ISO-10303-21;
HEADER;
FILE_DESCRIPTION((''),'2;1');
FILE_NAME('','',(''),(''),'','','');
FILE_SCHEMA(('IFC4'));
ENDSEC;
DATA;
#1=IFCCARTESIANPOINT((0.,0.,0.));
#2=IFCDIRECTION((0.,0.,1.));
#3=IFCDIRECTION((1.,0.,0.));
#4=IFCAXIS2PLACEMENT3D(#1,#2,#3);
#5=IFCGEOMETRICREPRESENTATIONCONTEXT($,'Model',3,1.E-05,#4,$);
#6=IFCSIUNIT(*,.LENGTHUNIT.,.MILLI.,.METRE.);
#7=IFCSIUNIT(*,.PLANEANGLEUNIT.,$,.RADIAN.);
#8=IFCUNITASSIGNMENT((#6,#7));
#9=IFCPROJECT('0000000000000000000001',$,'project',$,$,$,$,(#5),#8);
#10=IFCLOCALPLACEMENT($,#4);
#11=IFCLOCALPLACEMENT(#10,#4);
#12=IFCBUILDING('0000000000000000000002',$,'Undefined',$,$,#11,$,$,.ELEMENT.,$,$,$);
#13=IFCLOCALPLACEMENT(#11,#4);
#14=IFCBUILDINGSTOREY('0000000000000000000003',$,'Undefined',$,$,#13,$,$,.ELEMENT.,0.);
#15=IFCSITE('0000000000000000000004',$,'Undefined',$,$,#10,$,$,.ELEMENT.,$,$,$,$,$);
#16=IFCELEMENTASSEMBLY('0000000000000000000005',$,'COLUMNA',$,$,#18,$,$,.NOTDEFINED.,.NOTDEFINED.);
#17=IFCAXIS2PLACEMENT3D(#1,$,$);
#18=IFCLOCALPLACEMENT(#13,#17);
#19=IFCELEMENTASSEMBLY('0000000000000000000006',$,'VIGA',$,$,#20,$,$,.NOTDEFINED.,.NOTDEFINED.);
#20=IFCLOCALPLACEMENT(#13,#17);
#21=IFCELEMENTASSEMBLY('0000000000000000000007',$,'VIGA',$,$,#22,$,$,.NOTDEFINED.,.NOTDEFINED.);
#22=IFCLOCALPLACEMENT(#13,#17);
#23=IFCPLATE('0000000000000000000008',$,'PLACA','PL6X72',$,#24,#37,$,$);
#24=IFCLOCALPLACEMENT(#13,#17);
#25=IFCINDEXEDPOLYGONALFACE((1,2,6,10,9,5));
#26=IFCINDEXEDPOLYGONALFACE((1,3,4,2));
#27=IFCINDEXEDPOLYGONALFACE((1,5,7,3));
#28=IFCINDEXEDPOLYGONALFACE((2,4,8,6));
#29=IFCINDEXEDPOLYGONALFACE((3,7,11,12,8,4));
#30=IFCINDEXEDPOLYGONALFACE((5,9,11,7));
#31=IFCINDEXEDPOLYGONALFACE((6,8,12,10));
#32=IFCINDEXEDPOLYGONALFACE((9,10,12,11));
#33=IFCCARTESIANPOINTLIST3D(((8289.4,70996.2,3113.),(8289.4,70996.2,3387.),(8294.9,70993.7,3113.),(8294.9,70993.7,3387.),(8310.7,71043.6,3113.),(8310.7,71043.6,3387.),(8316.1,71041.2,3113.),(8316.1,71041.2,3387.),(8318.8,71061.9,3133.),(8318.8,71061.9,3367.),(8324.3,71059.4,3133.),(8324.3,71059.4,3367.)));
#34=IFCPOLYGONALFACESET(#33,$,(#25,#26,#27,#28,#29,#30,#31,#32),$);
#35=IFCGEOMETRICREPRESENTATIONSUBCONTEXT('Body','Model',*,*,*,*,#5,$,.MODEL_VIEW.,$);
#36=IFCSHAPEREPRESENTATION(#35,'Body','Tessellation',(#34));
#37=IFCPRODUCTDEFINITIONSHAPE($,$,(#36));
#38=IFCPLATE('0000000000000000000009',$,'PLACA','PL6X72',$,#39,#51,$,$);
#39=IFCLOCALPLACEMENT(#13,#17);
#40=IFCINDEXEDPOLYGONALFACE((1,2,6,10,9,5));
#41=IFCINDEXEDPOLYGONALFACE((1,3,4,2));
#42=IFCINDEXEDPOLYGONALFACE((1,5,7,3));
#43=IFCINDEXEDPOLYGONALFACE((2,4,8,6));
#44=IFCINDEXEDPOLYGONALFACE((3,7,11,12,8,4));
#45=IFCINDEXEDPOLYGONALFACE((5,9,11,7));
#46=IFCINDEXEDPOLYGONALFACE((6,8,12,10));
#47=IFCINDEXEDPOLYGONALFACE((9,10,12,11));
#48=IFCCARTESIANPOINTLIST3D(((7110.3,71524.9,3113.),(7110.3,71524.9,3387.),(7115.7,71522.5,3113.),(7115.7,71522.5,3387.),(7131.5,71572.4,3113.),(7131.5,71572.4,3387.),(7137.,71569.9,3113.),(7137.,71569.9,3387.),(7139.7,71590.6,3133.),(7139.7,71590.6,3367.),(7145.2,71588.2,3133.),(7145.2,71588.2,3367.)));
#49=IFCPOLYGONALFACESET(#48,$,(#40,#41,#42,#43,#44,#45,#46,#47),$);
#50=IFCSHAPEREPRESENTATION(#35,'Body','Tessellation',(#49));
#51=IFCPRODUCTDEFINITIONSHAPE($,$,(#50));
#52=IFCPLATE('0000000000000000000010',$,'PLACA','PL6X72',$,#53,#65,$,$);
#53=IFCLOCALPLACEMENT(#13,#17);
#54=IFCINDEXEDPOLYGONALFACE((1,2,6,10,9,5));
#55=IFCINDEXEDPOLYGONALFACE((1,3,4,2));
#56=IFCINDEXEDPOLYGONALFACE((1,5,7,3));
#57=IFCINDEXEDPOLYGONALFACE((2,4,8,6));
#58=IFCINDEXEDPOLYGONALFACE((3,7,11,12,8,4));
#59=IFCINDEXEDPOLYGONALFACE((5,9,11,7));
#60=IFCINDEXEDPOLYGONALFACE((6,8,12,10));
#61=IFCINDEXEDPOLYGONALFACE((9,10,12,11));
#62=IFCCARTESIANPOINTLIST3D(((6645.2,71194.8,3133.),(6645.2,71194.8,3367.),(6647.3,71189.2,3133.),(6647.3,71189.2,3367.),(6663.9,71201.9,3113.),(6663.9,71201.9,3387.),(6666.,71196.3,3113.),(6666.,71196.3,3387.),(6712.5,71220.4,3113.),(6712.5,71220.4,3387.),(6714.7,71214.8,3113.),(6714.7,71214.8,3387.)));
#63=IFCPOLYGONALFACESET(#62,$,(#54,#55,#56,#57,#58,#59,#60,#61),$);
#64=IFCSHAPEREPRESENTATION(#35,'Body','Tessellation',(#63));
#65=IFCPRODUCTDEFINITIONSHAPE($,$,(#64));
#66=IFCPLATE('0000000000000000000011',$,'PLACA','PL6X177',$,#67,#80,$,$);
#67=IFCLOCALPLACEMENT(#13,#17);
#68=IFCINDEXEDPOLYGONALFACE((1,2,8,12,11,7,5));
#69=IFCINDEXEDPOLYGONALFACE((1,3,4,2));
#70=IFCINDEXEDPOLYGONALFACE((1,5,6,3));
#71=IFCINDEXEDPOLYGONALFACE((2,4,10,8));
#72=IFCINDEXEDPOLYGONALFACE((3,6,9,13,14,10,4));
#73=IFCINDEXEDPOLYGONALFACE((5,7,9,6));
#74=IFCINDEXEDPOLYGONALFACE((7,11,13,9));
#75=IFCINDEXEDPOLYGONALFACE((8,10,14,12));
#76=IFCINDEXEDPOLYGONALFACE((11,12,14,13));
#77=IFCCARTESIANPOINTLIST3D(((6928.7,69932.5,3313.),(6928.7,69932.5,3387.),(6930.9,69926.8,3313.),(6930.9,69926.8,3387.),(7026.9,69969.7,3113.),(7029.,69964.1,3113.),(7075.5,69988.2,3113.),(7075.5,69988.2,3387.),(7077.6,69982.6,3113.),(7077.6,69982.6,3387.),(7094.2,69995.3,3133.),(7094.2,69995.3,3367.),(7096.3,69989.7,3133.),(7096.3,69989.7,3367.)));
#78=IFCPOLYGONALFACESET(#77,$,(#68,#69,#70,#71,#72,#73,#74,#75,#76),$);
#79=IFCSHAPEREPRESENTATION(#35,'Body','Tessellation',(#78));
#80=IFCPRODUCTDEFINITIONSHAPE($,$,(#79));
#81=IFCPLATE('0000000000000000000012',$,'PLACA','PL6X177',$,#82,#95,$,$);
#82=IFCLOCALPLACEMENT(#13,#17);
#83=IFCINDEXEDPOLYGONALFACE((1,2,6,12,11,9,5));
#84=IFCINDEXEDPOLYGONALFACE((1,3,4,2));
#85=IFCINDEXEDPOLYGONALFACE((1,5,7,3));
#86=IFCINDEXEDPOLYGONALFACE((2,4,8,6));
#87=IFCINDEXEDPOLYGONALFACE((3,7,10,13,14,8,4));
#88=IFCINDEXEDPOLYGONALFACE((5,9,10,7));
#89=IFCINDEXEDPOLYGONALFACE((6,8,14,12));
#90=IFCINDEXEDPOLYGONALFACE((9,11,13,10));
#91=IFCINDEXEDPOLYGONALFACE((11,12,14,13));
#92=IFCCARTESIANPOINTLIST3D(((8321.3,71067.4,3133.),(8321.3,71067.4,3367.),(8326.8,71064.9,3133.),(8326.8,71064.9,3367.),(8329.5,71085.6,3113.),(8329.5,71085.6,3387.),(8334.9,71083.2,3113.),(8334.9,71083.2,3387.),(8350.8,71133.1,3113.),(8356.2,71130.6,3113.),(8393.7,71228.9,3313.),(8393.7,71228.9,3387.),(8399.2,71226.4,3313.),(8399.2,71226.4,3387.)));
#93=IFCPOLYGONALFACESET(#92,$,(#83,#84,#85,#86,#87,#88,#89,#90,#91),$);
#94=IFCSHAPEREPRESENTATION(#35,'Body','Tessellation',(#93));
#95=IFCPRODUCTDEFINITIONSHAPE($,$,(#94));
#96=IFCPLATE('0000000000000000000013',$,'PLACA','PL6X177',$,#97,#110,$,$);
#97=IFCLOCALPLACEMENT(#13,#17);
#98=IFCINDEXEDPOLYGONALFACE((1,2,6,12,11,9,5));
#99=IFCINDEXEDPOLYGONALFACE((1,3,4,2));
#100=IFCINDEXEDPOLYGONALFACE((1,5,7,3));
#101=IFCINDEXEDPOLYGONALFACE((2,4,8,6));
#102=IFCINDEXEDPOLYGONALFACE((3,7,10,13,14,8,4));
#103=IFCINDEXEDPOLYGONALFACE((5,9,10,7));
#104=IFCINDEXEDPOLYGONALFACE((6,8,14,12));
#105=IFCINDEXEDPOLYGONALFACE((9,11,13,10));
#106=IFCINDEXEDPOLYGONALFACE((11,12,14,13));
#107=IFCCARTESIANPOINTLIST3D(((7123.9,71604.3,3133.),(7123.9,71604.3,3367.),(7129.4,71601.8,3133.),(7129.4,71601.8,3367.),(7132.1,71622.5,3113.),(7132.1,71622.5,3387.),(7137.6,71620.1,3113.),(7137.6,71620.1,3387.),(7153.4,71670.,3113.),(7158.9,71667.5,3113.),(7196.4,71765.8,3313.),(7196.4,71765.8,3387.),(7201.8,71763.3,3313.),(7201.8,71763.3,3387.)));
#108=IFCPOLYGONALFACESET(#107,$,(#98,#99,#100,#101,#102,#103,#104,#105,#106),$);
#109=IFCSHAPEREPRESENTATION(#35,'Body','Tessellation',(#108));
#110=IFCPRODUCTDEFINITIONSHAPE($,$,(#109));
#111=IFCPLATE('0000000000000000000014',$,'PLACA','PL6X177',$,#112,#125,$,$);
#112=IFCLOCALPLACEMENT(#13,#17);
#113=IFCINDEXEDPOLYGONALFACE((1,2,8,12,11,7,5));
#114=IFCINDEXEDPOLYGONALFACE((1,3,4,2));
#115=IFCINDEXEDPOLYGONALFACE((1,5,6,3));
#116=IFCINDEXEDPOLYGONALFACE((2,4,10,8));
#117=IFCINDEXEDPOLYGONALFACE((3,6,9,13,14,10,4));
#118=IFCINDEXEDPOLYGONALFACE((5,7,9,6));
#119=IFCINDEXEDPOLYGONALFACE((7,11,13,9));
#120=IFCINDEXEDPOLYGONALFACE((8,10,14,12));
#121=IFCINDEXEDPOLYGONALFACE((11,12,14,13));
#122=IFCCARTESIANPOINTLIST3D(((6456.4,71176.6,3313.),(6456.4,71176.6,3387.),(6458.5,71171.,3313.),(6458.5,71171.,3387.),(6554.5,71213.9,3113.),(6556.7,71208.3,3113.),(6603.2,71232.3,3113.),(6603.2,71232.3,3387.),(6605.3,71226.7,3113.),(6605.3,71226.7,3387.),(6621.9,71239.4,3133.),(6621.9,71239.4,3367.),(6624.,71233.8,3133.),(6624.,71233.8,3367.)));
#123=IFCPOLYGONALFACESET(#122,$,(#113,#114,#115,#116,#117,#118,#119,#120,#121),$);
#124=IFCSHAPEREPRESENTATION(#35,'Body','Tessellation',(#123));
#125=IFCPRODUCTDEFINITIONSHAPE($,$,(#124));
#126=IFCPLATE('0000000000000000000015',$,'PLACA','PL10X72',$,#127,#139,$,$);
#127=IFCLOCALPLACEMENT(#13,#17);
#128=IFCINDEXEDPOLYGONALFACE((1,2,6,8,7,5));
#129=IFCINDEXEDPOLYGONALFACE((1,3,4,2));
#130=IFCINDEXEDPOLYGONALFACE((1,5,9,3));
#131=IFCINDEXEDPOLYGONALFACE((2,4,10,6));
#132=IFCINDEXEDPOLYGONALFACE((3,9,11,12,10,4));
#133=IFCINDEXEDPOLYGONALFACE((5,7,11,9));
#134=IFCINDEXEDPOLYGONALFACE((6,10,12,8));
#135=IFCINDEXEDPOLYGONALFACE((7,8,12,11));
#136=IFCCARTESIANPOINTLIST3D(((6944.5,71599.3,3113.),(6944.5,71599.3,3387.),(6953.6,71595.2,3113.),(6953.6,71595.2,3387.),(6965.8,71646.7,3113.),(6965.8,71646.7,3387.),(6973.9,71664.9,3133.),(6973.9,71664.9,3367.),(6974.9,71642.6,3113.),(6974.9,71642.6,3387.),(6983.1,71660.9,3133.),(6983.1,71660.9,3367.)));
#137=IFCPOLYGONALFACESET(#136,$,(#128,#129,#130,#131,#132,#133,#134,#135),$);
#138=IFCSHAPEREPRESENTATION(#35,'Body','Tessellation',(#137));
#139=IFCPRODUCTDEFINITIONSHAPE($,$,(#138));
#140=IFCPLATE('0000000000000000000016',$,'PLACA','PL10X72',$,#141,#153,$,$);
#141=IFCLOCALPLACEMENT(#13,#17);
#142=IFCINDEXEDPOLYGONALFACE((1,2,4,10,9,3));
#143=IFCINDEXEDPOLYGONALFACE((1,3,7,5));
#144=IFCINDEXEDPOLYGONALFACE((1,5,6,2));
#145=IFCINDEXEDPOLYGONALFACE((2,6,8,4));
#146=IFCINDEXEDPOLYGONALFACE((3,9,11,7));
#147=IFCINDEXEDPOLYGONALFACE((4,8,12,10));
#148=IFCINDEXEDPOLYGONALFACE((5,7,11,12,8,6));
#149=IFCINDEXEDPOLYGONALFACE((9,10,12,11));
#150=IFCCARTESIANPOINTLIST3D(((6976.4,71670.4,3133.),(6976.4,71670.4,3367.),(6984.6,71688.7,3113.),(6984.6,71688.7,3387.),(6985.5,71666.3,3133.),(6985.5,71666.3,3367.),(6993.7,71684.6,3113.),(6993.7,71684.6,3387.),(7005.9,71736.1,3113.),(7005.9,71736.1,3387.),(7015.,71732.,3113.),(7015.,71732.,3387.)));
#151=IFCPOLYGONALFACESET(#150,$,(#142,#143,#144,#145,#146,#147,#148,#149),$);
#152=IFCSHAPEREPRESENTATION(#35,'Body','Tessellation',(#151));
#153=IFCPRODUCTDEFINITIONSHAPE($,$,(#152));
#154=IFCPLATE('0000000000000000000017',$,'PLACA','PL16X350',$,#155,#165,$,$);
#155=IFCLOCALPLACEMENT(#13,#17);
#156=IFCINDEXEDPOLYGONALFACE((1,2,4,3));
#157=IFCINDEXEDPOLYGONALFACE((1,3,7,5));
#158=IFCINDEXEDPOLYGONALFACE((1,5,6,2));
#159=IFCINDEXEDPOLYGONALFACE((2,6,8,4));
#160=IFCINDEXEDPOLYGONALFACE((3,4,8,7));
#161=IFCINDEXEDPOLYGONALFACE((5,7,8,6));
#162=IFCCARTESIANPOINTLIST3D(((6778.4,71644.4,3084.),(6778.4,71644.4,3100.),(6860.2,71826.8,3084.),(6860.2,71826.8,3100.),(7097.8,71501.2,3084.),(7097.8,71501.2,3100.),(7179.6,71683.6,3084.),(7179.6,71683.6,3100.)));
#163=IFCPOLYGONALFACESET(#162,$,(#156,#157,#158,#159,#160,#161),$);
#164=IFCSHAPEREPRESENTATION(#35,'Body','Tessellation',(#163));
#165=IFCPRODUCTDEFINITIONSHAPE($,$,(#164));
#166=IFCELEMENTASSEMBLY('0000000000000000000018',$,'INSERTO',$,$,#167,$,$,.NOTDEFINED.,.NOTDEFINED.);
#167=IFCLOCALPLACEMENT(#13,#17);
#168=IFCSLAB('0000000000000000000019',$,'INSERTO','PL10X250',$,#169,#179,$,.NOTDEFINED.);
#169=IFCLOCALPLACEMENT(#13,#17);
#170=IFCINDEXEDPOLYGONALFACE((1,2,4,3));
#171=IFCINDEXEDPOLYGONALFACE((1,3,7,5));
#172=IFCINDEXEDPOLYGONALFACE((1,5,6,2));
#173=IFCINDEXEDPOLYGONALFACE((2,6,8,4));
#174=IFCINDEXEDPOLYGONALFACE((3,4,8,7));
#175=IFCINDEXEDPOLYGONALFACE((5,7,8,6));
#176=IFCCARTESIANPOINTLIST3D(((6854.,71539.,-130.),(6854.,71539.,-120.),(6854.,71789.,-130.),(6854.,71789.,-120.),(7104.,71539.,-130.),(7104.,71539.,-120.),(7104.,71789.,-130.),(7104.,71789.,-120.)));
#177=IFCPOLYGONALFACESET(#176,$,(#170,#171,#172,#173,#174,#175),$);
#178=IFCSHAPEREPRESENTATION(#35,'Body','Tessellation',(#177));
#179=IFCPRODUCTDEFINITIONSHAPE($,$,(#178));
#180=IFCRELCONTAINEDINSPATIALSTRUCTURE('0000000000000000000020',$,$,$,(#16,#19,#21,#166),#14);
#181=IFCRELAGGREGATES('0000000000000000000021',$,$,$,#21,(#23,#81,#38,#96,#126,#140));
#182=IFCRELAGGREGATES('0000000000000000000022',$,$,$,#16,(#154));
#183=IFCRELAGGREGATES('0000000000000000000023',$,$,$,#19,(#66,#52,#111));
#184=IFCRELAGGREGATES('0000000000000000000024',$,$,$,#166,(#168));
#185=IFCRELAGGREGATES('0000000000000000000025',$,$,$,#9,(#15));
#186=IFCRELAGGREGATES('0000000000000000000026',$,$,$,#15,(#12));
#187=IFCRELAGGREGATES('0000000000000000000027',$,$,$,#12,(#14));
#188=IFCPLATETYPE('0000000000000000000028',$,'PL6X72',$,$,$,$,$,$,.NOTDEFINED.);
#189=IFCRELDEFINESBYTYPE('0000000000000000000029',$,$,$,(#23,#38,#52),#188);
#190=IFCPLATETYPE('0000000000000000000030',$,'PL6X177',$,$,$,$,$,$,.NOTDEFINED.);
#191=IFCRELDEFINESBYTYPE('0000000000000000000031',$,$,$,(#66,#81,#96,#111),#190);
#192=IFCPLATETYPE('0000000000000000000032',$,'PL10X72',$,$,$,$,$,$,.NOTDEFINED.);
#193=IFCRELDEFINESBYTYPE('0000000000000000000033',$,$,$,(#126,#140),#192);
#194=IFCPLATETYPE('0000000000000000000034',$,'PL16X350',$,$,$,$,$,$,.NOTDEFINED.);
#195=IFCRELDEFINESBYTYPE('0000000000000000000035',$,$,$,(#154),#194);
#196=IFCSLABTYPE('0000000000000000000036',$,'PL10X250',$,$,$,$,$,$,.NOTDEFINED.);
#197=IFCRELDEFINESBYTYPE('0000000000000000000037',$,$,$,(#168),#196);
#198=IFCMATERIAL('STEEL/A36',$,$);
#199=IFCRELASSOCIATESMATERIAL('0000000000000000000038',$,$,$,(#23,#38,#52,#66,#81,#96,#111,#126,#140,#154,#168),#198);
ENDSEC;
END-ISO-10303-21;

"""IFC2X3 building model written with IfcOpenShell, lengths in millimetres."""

from ifc_helpers import new_model, si_unit, frame, origin_with_axes, place, context, subcontext, project, spatial, polyline, outline, extrude, material, type_object, element, aggregate, save


model = new_model("IFC2X3")

# Units and contexts
model_context = context("Model", 3, precision=1e-05, world=origin_with_axes())
body_context = subcontext(model_context, "Body", "Model", "MODEL_VIEW")
ifc_project = project(units=[si_unit("LENGTHUNIT", "METRE", prefix="MILLI"), si_unit("PLANEANGLEUNIT", "RADIAN")], contexts=[model_context])

# Site, building, storey
site_placement = place(None, origin_with_axes())
site = spatial("IfcSite", under=ifc_project, at=site_placement, Name="Undefined", CompositionType="ELEMENT")
building_placement = place(site_placement, origin_with_axes())
building = spatial("IfcBuilding", under=site, at=building_placement, Name="Undefined", CompositionType="ELEMENT")
storey_placement = place(building_placement, origin_with_axes())
storey = spatial("IfcBuildingStorey", under=building, at=storey_placement, Name="Undefined", CompositionType="ELEMENT", Elevation=0.0)

# Element assembly
assembly_1_placement = place(storey_placement, origin_with_axes())
assembly_1 = element("IfcElementAssembly", 1, at=assembly_1_placement, inside=storey, Name="COLUMNA", AssemblyPlace="NOTDEFINED", PredefinedType="NOTDEFINED")

# Shared definitions
ifc_material_1 = material(Name="STEEL/A36")

# Element assembly
assembly_2_placement = place(storey_placement, origin_with_axes())
assembly_2 = element("IfcElementAssembly", 2, at=assembly_2_placement, inside=storey, Name="VIGA", AssemblyPlace="NOTDEFINED", PredefinedType="NOTDEFINED")
plate_type_1 = type_object("IfcPlateType", Name="PL6X72", PredefinedType="NOTDEFINED")

# Element assembly, plates
assembly_3_placement = place(storey_placement, origin_with_axes())
assembly_3 = element("IfcElementAssembly", 3, at=assembly_3_placement, inside=storey, Name="VIGA", AssemblyPlace="NOTDEFINED", PredefinedType="NOTDEFINED")
plate_1_placement = place(assembly_3_placement, frame((8292.1, 70995.0, 3113.0), z_axis=(0.912465, -0.409155, 0.0), x_axis=(0.409155, 0.912465, 0.0)))
plate_1 = element("IfcPlate", 4, at=plate_1_placement, type_object=plate_type_1, material=ifc_material_1, Name="PLACA", Description="PL6X72", context=body_context, shape_type="SweptSolid", body=[
    extrude(outline(polyline([(0.0, 0.0), (52.0, 0.0), (72.0, 20.0), (72.0, 254.0), (52.0, 274.0), (0.0, 274.0), (0.0, 0.0)])), frame((0.0, 0.0, -3.0), z_axis=(0.0, 0.0, 1.0), x_axis=(1.0, 0.0, 0.0)), (0.0, 0.0, 1.0), 6.0),
])
plate_2_placement = place(assembly_3_placement, frame((7113.0, 71523.7, 3113.0), z_axis=(0.912465, -0.409155, 0.0), x_axis=(0.409155, 0.912465, 0.0)))
plate_2 = element("IfcPlate", 5, at=plate_2_placement, type_object=plate_type_1, material=ifc_material_1, Name="PLACA", Description="PL6X72", context=body_context, shape_type="SweptSolid", body=[
    extrude(outline(polyline([(0.0, 0.0), (52.0, 0.0), (72.0, 20.0), (72.0, 254.0), (52.0, 274.0), (0.0, 274.0), (0.0, 0.0)])), frame((0.0, 0.0, -3.0), z_axis=(0.0, 0.0, 1.0), x_axis=(1.0, 0.0, 0.0)), (0.0, 0.0, 1.0), 6.0),
])

# Plates
plate_3_placement = place(assembly_2_placement, frame((6713.6, 71217.6, 3113.0), z_axis=(-0.354934, 0.934891, 0.0), x_axis=(-0.934891, -0.354934, 0.0)))
plate_3 = element("IfcPlate", 6, at=plate_3_placement, type_object=plate_type_1, material=ifc_material_1, Name="PLACA", Description="PL6X72", context=body_context, shape_type="SweptSolid", body=[
    extrude(outline(polyline([(0.0, 0.0), (52.0, 0.0), (72.0, 20.0), (72.0, 254.0), (52.0, 274.0), (0.0, 274.0), (0.0, 0.0)])), frame((0.0, 0.0, -3.0), z_axis=(0.0, 0.0, 1.0), x_axis=(1.0, 0.0, 0.0)), (0.0, 0.0, 1.0), 6.0),
])
plate_type_2 = type_object("IfcPlateType", Name="PL6X177", PredefinedType="NOTDEFINED")
plate_4_placement = place(assembly_2_placement, frame((7095.3, 69992.5, 3113.0), z_axis=(-0.354934, 0.934891, 0.0), x_axis=(-0.934891, -0.354934, 0.0)))
plate_4 = element("IfcPlate", 7, at=plate_4_placement, type_object=plate_type_2, material=ifc_material_1, Name="PLACA", Description="PL6X177", context=body_context, shape_type="SweptSolid", body=[
    extrude(outline(polyline([(0.0, 20.0), (20.0, 0.0), (72.0, 0.0), (177.0, 200.0), (177.0, 274.0), (20.0, 274.0), (0.0, 254.0), (0.0, 20.0)])), frame((0.0, 0.0, -3.0), z_axis=(0.0, 0.0, 1.0), x_axis=(1.0, 0.0, 0.0)), (0.0, 0.0, 1.0), 6.0),
])
plate_5_placement = place(assembly_3_placement, frame((8324.0, 71066.1, 3113.0), z_axis=(0.912465, -0.409155, 0.0), x_axis=(0.409155, 0.912465, 0.0)))
plate_5 = element("IfcPlate", 8, at=plate_5_placement, type_object=plate_type_2, material=ifc_material_1, Name="PLACA", Description="PL6X177", context=body_context, shape_type="SweptSolid", body=[
    extrude(outline(polyline([(0.0, 20.0), (20.0, 0.0), (72.0, 0.0), (177.0, 200.0), (177.0, 274.0), (20.0, 274.0), (0.0, 254.0), (0.0, 20.0)])), frame((0.0, 0.0, -3.0), z_axis=(0.0, 0.0, 1.0), x_axis=(1.0, 0.0, 0.0)), (0.0, 0.0, 1.0), 6.0),
])
plate_6_placement = place(assembly_3_placement, frame((7126.7, 71603.0, 3113.0), z_axis=(0.912465, -0.409155, 0.0), x_axis=(0.409155, 0.912465, 0.0)))
plate_6 = element("IfcPlate", 9, at=plate_6_placement, type_object=plate_type_2, material=ifc_material_1, Name="PLACA", Description="PL6X177", context=body_context, shape_type="SweptSolid", body=[
    extrude(outline(polyline([(0.0, 20.0), (20.0, 0.0), (72.0, 0.0), (177.0, 200.0), (177.0, 274.0), (20.0, 274.0), (0.0, 254.0), (0.0, 20.0)])), frame((0.0, 0.0, -3.0), z_axis=(0.0, 0.0, 1.0), x_axis=(1.0, 0.0, 0.0)), (0.0, 0.0, 1.0), 6.0),
])
plate_7_placement = place(assembly_2_placement, frame((6622.9, 71236.6, 3113.0), z_axis=(-0.354934, 0.934891, 0.0), x_axis=(-0.934891, -0.354934, 0.0)))
plate_7 = element("IfcPlate", 10, at=plate_7_placement, type_object=plate_type_2, material=ifc_material_1, Name="PLACA", Description="PL6X177", context=body_context, shape_type="SweptSolid", body=[
    extrude(outline(polyline([(0.0, 20.0), (20.0, 0.0), (72.0, 0.0), (177.0, 200.0), (177.0, 274.0), (20.0, 274.0), (0.0, 254.0), (0.0, 20.0)])), frame((0.0, 0.0, -3.0), z_axis=(0.0, 0.0, 1.0), x_axis=(1.0, 0.0, 0.0)), (0.0, 0.0, 1.0), 6.0),
])
plate_type_3 = type_object("IfcPlateType", Name="PL10X72", PredefinedType="NOTDEFINED")
plate_8_placement = place(assembly_3_placement, frame((6949.0, 71597.2, 3113.0), z_axis=(0.912465, -0.409155, 0.0), x_axis=(0.409155, 0.912465, 0.0)))
plate_8 = element("IfcPlate", 11, at=plate_8_placement, type_object=plate_type_3, material=ifc_material_1, Name="PLACA", Description="PL10X72", context=body_context, shape_type="SweptSolid", body=[
    extrude(outline(polyline([(0.0, 0.0), (52.0, 0.0), (72.0, 20.0), (72.0, 254.0), (52.0, 274.0), (0.0, 274.0), (0.0, 0.0)])), frame((0.0, 0.0, -5.0), z_axis=(0.0, 0.0, 1.0), x_axis=(1.0, 0.0, 0.0)), (0.0, 0.0, 1.0), 10.0),
])
plate_9_placement = place(assembly_3_placement, frame((6981.0, 71668.4, 3113.0), z_axis=(0.912465, -0.409155, 0.0), x_axis=(0.409155, 0.912465, 0.0)))
plate_9 = element("IfcPlate", 12, at=plate_9_placement, type_object=plate_type_3, material=ifc_material_1, Name="PLACA", Description="PL10X72", context=body_context, shape_type="SweptSolid", body=[
    extrude(outline(polyline([(0.0, 20.0), (20.0, 0.0), (72.0, 0.0), (72.0, 274.0), (20.0, 274.0), (0.0, 254.0), (0.0, 20.0)])), frame((0.0, 0.0, -5.0), z_axis=(0.0, 0.0, 1.0), x_axis=(1.0, 0.0, 0.0)), (0.0, 0.0, 1.0), 10.0),
])
aggregate(assembly_3, [plate_1, plate_5, plate_2, plate_6, plate_8, plate_9])
plate_type_4 = type_object("IfcPlateType", Name="PL16X350", PredefinedType="NOTDEFINED")
plate_10_placement = place(assembly_1_placement, frame((6938.1, 71572.8, 3092.0), z_axis=(0.0, 0.0, -1.0), x_axis=(0.409155, 0.912465, 0.0)))
plate_10 = element("IfcPlate", 13, at=plate_10_placement, type_object=plate_type_4, material=ifc_material_1, Name="PLACA", Description="PL16X350", context=body_context, shape_type="SweptSolid", body=[
    extrude(outline(polyline([(0.0, -175.0), (0.0, 175.0), (200.0, 175.0), (200.0, -175.0), (0.0, -175.0)])), frame((0.0, 0.0, -8.0), z_axis=(0.0, 0.0, 1.0), x_axis=(1.0, 0.0, 0.0)), (0.0, 0.0, 1.0), 16.0),
])
aggregate(assembly_1, [plate_10])

# Element assembly, slab
assembly_4_placement = place(storey_placement, origin_with_axes())
assembly_4 = element("IfcElementAssembly", 14, at=assembly_4_placement, inside=storey, Name="INSERTO", AssemblyPlace="NOTDEFINED", PredefinedType="NOTDEFINED")
slab_type = type_object("IfcSlabType", Name="PL10X250", PredefinedType="NOTDEFINED")
slab_placement = place(assembly_4_placement, frame((6854.0, 71539.0, -125.0), z_axis=(0.0, 0.0, 1.0), x_axis=(1.0, 0.0, 0.0)))
slab = element("IfcSlab", 15, at=slab_placement, type_object=slab_type, material=ifc_material_1, Name="INSERTO", Description="PL10X250", PredefinedType="NOTDEFINED", context=body_context, shape_type="SweptSolid", body=[
    extrude(outline(polyline([(0.0, 0.0), (250.0, 0.0), (250.0, 250.0), (0.0, 250.0), (0.0, 0.0)])), frame((0.0, 0.0, -5.0), z_axis=(0.0, 0.0, 1.0), x_axis=(1.0, 0.0, 0.0)), (0.0, 0.0, 1.0), 10.0),
])

aggregate(assembly_2, [plate_4, plate_3, plate_7])
aggregate(assembly_4, [slab])

save(model, "model.ifc")
